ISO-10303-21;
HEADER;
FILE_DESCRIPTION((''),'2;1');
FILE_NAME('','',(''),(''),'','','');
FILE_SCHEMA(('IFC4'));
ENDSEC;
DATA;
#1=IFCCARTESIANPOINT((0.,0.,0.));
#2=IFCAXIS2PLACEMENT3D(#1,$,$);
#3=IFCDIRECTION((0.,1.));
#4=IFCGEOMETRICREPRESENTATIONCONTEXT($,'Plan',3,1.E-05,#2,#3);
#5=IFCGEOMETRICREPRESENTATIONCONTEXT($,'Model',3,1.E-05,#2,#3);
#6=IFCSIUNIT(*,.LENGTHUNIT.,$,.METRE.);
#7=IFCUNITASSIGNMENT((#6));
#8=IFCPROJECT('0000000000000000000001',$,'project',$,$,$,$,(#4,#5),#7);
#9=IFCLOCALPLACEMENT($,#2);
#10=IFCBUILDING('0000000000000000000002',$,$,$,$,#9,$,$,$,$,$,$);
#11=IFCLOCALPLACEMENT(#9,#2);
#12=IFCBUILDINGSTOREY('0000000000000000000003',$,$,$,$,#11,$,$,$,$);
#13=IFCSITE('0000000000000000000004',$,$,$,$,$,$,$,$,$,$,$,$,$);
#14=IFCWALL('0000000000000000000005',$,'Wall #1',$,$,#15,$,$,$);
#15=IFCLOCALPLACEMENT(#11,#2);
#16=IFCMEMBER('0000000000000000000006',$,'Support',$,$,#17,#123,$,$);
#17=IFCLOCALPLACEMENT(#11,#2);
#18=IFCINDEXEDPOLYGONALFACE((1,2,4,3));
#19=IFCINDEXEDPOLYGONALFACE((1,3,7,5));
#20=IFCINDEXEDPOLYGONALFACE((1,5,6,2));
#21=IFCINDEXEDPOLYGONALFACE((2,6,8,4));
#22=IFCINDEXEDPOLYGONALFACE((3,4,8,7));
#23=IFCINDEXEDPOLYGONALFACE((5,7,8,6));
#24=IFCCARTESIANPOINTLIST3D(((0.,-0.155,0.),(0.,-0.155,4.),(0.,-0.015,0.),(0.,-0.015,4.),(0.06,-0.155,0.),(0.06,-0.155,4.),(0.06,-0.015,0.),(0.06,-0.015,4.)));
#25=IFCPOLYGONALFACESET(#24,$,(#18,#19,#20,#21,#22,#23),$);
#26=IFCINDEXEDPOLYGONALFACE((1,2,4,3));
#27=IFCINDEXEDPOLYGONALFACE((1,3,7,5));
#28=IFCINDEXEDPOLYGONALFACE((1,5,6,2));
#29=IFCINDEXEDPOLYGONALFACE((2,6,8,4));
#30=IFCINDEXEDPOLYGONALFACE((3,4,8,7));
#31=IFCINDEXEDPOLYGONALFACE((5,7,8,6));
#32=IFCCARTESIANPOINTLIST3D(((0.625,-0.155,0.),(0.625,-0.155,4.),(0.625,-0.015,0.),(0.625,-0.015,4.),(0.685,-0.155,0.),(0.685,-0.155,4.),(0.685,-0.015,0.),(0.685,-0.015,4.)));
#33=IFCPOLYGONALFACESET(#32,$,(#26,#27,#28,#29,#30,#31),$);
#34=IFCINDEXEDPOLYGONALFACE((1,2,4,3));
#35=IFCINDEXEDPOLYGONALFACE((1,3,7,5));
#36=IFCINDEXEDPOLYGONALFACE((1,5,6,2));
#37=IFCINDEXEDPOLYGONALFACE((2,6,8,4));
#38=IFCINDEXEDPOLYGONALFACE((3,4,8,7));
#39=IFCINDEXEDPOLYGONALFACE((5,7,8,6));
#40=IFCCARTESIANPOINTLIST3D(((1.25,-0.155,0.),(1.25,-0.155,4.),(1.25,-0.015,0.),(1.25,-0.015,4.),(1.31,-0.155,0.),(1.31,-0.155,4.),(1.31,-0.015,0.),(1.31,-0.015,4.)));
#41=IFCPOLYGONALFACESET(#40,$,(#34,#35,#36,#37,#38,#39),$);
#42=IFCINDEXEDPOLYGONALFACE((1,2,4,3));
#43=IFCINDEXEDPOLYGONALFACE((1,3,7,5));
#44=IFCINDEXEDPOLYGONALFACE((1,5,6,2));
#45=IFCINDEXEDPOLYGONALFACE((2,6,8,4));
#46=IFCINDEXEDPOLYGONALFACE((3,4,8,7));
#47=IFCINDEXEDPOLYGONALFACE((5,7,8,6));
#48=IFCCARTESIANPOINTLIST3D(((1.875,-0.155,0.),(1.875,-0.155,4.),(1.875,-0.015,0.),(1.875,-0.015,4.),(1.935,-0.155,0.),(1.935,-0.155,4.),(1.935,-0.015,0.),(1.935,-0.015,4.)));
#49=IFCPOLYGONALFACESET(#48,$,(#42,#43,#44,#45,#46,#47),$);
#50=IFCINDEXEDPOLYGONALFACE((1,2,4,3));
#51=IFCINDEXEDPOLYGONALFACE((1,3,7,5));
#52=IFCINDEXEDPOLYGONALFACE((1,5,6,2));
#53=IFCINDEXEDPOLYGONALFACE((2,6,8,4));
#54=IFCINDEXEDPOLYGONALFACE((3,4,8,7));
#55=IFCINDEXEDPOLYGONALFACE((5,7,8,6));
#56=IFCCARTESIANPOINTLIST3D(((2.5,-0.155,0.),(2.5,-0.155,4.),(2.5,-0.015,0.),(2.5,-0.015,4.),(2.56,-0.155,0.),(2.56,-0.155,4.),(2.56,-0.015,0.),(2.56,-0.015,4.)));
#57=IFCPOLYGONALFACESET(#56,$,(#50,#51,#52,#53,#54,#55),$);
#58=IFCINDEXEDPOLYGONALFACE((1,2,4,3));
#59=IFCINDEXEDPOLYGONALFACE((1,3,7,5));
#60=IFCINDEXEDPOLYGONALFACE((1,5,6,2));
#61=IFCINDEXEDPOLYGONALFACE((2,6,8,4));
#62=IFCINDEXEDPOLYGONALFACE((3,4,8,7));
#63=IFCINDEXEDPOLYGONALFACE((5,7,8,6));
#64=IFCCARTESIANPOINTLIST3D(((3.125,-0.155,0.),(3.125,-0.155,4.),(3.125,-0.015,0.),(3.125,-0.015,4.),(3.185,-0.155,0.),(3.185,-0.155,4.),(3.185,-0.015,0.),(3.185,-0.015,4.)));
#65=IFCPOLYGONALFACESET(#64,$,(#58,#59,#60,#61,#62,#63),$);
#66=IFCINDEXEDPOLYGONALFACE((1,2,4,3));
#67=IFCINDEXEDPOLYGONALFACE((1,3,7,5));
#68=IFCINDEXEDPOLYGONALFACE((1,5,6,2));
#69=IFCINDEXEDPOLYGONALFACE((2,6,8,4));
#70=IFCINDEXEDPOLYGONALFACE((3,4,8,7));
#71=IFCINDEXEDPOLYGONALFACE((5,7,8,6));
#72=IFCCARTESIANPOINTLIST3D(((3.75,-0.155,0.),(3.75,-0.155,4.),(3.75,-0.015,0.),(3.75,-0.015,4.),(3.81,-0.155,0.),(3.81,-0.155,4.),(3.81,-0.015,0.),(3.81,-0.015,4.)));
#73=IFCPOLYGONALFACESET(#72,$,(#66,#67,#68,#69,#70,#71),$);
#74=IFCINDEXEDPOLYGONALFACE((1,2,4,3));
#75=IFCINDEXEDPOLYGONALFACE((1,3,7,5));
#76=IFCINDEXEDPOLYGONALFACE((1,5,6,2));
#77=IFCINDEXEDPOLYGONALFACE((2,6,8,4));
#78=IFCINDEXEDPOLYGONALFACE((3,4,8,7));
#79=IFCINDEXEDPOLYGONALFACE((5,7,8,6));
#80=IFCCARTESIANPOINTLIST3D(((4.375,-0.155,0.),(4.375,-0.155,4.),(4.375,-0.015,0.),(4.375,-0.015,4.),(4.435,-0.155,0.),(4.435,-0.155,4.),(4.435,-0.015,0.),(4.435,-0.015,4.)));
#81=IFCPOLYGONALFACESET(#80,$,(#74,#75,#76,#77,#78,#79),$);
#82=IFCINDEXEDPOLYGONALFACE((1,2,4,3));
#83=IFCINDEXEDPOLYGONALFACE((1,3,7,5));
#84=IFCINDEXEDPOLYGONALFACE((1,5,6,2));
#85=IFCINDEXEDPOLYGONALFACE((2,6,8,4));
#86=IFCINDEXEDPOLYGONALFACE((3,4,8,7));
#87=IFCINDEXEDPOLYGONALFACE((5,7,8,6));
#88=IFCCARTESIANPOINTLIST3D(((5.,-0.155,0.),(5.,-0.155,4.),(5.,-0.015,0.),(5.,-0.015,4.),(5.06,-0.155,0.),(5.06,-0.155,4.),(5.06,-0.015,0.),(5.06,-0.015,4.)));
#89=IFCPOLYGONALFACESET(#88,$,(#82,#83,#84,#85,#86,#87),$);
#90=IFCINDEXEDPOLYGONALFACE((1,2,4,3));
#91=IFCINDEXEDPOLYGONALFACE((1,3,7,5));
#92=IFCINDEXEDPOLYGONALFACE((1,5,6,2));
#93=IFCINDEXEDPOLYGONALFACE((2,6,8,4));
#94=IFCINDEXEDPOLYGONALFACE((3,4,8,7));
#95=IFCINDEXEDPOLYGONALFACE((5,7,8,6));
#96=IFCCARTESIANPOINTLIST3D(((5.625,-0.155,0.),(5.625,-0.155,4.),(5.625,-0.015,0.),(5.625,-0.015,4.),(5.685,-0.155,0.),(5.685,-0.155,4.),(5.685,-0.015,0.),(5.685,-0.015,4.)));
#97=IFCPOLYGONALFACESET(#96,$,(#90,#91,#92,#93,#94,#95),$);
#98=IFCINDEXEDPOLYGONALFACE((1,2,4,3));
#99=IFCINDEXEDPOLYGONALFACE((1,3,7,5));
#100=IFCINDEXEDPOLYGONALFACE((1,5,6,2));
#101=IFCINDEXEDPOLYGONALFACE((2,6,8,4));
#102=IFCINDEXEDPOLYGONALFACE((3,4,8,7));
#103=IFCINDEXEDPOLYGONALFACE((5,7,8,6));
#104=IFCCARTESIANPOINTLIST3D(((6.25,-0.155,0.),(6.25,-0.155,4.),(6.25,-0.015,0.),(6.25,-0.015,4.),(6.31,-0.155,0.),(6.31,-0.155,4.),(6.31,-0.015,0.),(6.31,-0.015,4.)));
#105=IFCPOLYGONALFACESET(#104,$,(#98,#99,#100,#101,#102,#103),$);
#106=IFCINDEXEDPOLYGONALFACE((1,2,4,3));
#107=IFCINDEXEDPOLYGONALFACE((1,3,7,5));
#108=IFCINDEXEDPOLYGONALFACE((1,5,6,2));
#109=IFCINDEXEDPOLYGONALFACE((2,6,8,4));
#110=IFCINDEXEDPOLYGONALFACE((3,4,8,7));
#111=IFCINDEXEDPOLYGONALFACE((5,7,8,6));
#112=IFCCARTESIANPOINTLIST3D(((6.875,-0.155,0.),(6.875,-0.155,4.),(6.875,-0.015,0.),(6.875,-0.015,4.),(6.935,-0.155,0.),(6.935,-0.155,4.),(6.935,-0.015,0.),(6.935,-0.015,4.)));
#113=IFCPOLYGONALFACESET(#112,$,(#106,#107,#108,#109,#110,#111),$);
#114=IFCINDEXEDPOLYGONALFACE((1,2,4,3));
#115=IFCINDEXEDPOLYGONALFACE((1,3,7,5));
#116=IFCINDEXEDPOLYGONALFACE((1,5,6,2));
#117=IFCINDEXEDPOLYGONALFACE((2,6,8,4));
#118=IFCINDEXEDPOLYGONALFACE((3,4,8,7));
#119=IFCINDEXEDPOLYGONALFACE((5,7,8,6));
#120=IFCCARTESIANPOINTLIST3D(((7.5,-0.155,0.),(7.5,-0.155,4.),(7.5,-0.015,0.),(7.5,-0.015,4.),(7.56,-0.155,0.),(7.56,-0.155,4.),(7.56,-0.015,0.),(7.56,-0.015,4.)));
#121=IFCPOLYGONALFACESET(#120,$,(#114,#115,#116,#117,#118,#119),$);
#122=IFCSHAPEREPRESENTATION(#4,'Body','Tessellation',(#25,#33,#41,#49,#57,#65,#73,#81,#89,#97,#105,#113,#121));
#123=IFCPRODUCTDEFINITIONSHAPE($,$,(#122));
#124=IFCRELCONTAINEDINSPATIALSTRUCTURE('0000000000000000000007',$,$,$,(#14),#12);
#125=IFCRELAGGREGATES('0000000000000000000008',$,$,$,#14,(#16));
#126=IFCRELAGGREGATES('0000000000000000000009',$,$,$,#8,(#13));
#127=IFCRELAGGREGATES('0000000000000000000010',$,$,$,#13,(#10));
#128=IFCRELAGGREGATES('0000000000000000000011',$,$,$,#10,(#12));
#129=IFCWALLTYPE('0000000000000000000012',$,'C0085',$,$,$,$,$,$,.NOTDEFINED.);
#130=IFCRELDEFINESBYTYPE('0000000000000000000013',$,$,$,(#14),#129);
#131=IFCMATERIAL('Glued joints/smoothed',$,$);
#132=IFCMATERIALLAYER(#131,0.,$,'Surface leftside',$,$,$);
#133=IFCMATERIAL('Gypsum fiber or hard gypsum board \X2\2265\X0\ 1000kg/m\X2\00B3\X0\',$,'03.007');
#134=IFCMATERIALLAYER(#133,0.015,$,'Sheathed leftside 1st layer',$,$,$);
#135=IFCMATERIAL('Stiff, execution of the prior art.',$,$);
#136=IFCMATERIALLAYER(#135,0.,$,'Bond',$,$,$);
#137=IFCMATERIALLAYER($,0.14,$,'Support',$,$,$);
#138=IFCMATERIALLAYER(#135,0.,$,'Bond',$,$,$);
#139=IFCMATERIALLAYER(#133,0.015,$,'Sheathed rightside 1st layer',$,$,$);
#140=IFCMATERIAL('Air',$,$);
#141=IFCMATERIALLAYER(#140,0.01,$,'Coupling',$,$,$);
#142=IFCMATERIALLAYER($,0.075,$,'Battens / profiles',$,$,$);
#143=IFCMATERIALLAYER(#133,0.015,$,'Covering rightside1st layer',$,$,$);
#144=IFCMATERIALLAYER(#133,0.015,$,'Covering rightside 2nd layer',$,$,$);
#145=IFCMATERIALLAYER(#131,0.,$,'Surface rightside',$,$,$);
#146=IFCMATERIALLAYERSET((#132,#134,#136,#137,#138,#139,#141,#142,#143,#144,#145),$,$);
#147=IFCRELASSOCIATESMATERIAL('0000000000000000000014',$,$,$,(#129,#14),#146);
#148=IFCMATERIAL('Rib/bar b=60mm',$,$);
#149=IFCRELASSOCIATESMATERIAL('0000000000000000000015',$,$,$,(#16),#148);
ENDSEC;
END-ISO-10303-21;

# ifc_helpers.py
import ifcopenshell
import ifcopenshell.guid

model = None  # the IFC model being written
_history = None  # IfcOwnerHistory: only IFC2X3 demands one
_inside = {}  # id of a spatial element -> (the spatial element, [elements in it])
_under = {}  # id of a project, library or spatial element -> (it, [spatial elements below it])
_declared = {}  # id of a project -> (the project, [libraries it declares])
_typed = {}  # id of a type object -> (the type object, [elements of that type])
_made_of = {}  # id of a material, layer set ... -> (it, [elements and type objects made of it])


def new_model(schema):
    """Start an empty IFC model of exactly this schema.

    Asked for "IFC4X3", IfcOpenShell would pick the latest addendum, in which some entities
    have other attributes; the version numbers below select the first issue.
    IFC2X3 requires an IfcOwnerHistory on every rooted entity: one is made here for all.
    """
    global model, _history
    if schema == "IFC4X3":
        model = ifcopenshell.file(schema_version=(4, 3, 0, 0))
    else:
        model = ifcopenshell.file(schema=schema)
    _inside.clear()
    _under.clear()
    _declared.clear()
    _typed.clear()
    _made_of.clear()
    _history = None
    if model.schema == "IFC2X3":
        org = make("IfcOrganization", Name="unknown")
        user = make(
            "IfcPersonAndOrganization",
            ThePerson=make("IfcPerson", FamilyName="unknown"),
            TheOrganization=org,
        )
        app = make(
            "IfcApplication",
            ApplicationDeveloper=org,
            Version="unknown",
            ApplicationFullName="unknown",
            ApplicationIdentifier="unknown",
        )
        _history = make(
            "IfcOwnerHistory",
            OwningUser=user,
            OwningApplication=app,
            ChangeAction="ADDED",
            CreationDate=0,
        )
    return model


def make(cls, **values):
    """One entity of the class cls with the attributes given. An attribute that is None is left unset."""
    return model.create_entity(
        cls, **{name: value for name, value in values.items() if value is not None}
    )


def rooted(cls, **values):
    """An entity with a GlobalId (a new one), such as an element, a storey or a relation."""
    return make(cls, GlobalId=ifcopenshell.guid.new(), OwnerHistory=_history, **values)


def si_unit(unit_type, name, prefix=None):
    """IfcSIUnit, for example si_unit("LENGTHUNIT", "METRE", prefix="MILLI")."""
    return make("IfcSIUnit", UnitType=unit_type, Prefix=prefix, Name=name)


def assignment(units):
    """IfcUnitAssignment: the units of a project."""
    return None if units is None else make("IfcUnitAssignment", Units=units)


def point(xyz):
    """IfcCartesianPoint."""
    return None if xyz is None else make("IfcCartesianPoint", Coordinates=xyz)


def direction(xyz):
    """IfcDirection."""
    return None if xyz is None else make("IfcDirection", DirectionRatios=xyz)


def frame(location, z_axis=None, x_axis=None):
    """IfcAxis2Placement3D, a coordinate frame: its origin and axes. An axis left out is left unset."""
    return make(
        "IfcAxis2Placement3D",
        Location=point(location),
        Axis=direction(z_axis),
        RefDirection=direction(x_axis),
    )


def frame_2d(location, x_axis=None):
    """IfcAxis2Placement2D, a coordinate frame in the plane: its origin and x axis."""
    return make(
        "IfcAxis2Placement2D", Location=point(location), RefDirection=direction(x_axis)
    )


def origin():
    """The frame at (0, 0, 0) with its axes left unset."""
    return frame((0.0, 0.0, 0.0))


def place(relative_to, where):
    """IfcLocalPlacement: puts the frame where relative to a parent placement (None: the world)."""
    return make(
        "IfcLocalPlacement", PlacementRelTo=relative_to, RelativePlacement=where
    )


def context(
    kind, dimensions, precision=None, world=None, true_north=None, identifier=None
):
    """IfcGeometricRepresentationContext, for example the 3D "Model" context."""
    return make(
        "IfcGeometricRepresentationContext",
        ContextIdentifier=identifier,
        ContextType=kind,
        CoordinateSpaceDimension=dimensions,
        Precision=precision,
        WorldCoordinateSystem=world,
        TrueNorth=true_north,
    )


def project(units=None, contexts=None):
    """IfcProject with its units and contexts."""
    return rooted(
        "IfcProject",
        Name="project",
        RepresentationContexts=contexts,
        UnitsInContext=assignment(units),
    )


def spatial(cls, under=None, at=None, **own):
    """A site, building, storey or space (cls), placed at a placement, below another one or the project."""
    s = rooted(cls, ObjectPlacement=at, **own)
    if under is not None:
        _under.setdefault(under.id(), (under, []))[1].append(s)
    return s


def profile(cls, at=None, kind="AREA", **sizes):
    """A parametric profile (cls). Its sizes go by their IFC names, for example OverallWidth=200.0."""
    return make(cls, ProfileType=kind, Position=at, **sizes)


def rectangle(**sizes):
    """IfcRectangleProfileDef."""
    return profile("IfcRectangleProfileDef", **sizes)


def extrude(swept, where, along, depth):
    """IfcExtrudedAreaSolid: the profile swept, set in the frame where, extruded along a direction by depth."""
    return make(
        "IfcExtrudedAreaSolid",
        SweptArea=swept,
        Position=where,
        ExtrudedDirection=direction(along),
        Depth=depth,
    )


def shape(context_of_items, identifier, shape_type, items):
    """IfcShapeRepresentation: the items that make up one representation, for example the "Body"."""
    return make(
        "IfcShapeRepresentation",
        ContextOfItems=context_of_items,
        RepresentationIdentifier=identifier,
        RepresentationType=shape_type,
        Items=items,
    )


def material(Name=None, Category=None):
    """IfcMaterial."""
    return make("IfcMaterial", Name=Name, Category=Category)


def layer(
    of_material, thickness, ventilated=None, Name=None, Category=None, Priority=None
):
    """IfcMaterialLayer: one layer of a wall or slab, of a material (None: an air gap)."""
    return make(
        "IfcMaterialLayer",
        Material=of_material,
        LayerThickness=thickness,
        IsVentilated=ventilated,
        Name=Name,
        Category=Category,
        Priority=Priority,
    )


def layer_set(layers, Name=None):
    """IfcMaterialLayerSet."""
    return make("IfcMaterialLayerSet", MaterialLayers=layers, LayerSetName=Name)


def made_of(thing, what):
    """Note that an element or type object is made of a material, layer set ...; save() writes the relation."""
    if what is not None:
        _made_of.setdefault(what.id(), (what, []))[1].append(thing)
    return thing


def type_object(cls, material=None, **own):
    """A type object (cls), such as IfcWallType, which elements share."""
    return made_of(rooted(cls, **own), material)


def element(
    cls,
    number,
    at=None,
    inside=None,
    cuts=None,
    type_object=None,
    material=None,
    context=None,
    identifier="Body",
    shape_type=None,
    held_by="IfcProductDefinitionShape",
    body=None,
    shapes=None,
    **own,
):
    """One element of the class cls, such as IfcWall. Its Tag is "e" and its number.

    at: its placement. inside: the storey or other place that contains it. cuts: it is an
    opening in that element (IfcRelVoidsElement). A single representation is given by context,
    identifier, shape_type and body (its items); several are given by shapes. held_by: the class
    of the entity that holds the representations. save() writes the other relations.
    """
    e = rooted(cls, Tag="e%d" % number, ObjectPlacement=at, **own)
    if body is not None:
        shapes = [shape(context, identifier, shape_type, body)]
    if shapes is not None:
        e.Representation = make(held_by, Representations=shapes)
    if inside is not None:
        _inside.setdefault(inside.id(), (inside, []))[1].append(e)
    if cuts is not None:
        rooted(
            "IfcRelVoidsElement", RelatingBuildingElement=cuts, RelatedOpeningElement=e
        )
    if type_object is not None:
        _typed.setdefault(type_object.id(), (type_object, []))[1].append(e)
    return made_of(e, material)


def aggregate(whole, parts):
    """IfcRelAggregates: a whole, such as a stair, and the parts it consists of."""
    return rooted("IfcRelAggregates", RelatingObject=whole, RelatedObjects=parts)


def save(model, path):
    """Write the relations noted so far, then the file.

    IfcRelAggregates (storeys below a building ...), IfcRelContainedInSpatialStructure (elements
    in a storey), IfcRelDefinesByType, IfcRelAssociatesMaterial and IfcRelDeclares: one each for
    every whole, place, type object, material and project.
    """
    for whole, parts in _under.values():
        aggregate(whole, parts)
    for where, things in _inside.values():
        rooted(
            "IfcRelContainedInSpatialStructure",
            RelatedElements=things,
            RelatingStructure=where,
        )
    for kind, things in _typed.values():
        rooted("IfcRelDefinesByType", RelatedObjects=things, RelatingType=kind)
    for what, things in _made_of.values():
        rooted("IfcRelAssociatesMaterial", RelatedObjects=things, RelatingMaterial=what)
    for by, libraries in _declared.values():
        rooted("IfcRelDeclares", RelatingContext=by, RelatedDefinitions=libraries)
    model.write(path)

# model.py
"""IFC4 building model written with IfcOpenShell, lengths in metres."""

from ifc_helpers import new_model, si_unit, direction, frame, frame_2d, origin, place, context, project, spatial, rectangle, extrude, material, layer, layer_set, type_object, element, aggregate, save


model = new_model("IFC4")

# Units and contexts
plan_context = context("Plan", 3, precision=1e-05, world=origin(), true_north=direction((0.0, 1.0)))
model_context = context("Model", 3, precision=1e-05, world=origin(), true_north=direction((0.0, 1.0)))
ifc_project = project(units=[si_unit("LENGTHUNIT", "METRE")], contexts=[plan_context, model_context])

# Site, building, storey
site = spatial("IfcSite", under=ifc_project)
building_placement = place(None, origin())
building = spatial("IfcBuilding", under=site, at=building_placement)
storey_placement = place(building_placement, origin())
storey = spatial("IfcBuildingStorey", under=building, at=storey_placement)

# Wall, member
ifc_material_1 = material(Name="Glued joints/smoothed")
ifc_layer_1 = layer(ifc_material_1, 0.0, Name="Surface leftside")
ifc_material_2 = material(Name="Gypsum fiber or hard gypsum board ≥ 1000kg/m³", Category="03.007")
ifc_layer_2 = layer(ifc_material_2, 0.015, Name="Sheathed leftside 1st layer")
ifc_material_3 = material(Name="Stiff, execution of the prior art.")
ifc_layer_3 = layer(ifc_material_3, 0.0, Name="Bond")
ifc_layer_4 = layer(None, 0.14, Name="Support")
ifc_layer_5 = layer(ifc_material_3, 0.0, Name="Bond")
ifc_layer_6 = layer(ifc_material_2, 0.015, Name="Sheathed rightside 1st layer")
ifc_material_4 = material(Name="Air")
ifc_layer_7 = layer(ifc_material_4, 0.01, Name="Coupling")
ifc_layer_8 = layer(None, 0.075, Name="Battens / profiles")
ifc_layer_9 = layer(ifc_material_2, 0.015, Name="Covering rightside1st layer")
ifc_layer_10 = layer(ifc_material_2, 0.015, Name="Covering rightside 2nd layer")
ifc_layer_11 = layer(ifc_material_1, 0.0, Name="Surface rightside")
ifc_layer_set = layer_set([ifc_layer_1, ifc_layer_2, ifc_layer_3, ifc_layer_4, ifc_layer_5, ifc_layer_6, ifc_layer_7, ifc_layer_8, ifc_layer_9, ifc_layer_10, ifc_layer_11])
wall_type = type_object("IfcWallType", Name="C0085", PredefinedType="NOTDEFINED", material=ifc_layer_set)
wall_placement = place(None, frame((0.0, 0.0, 0.0), z_axis=(0.0, -1.0, 0.0), x_axis=(1.0, 0.0, 0.0)))
wall = element("IfcWall", 1, at=wall_placement, inside=storey, type_object=wall_type, material=ifc_layer_set, Name="Wall #1")
ifc_material_5 = material(Name="Rib/bar b=60mm")
member_1_placement = place(wall_placement, origin())
member_1 = element("IfcMember", 2, at=member_1_placement, material=ifc_material_5, Name="Support", context=plan_context, shape_type="SweptSolid", body=[
    extrude(rectangle(XDim=0.06, YDim=0.14, at=frame_2d((0.03, 0.07), x_axis=(1.0, 0.0))), frame((0.0, 4.0, 0.015), z_axis=(0.0, -1.0, 0.0), x_axis=(1.0, 0.0, 0.0)), (0.0, 0.0, 1.0), 4.0),
    extrude(rectangle(XDim=0.06, YDim=0.14, at=frame_2d((0.03, 0.07), x_axis=(1.0, 0.0))), frame((0.625, 4.0, 0.015), z_axis=(0.0, -1.0, 0.0), x_axis=(1.0, 0.0, 0.0)), (0.0, 0.0, 1.0), 4.0),
    extrude(rectangle(XDim=0.06, YDim=0.14, at=frame_2d((0.03, 0.07), x_axis=(1.0, 0.0))), frame((1.25, 4.0, 0.015), z_axis=(0.0, -1.0, 0.0), x_axis=(1.0, 0.0, 0.0)), (0.0, 0.0, 1.0), 4.0),
    extrude(rectangle(XDim=0.06, YDim=0.14, at=frame_2d((0.03, 0.07), x_axis=(1.0, 0.0))), frame((1.875, 4.0, 0.015), z_axis=(0.0, -1.0, 0.0), x_axis=(1.0, 0.0, 0.0)), (0.0, 0.0, 1.0), 4.0),
    extrude(rectangle(XDim=0.06, YDim=0.14, at=frame_2d((0.03, 0.07), x_axis=(1.0, 0.0))), frame((2.5, 4.0, 0.015), z_axis=(0.0, -1.0, 0.0), x_axis=(1.0, 0.0, 0.0)), (0.0, 0.0, 1.0), 4.0),
    extrude(rectangle(XDim=0.06, YDim=0.14, at=frame_2d((0.03, 0.07), x_axis=(1.0, 0.0))), frame((3.125, 4.0, 0.015), z_axis=(0.0, -1.0, 0.0), x_axis=(1.0, 0.0, 0.0)), (0.0, 0.0, 1.0), 4.0),
    extrude(rectangle(XDim=0.06, YDim=0.14, at=frame_2d((0.03, 0.07), x_axis=(1.0, 0.0))), frame((3.75, 4.0, 0.015), z_axis=(0.0, -1.0, 0.0), x_axis=(1.0, 0.0, 0.0)), (0.0, 0.0, 1.0), 4.0),
    extrude(rectangle(XDim=0.06, YDim=0.14, at=frame_2d((0.03, 0.07), x_axis=(1.0, 0.0))), frame((4.375, 4.0, 0.015), z_axis=(0.0, -1.0, 0.0), x_axis=(1.0, 0.0, 0.0)), (0.0, 0.0, 1.0), 4.0),
    extrude(rectangle(XDim=0.06, YDim=0.14, at=frame_2d((0.03, 0.07), x_axis=(1.0, 0.0))), frame((5.0, 4.0, 0.015), z_axis=(0.0, -1.0, 0.0), x_axis=(1.0, 0.0, 0.0)), (0.0, 0.0, 1.0), 4.0),
    extrude(rectangle(XDim=0.06, YDim=0.14, at=frame_2d((0.03, 0.07), x_axis=(1.0, 0.0))), frame((5.625, 4.0, 0.015), z_axis=(0.0, -1.0, 0.0), x_axis=(1.0, 0.0, 0.0)), (0.0, 0.0, 1.0), 4.0),
    extrude(rectangle(XDim=0.06, YDim=0.14, at=frame_2d((0.03, 0.07), x_axis=(1.0, 0.0))), frame((6.25, 4.0, 0.015), z_axis=(0.0, -1.0, 0.0), x_axis=(1.0, 0.0, 0.0)), (0.0, 0.0, 1.0), 4.0),
    extrude(rectangle(XDim=0.06, YDim=0.14, at=frame_2d((0.03, 0.07), x_axis=(1.0, 0.0))), frame((6.875, 4.0, 0.015), z_axis=(0.0, -1.0, 0.0), x_axis=(1.0, 0.0, 0.0)), (0.0, 0.0, 1.0), 4.0),
    extrude(rectangle(XDim=0.06, YDim=0.14, at=frame_2d((0.03, 0.07), x_axis=(1.0, 0.0))), frame((7.5, 4.0, 0.015), z_axis=(0.0, -1.0, 0.0), x_axis=(1.0, 0.0, 0.0)), (0.0, 0.0, 1.0), 4.0),
])
aggregate(wall, [member_1])

save(model, "model.ifc")
